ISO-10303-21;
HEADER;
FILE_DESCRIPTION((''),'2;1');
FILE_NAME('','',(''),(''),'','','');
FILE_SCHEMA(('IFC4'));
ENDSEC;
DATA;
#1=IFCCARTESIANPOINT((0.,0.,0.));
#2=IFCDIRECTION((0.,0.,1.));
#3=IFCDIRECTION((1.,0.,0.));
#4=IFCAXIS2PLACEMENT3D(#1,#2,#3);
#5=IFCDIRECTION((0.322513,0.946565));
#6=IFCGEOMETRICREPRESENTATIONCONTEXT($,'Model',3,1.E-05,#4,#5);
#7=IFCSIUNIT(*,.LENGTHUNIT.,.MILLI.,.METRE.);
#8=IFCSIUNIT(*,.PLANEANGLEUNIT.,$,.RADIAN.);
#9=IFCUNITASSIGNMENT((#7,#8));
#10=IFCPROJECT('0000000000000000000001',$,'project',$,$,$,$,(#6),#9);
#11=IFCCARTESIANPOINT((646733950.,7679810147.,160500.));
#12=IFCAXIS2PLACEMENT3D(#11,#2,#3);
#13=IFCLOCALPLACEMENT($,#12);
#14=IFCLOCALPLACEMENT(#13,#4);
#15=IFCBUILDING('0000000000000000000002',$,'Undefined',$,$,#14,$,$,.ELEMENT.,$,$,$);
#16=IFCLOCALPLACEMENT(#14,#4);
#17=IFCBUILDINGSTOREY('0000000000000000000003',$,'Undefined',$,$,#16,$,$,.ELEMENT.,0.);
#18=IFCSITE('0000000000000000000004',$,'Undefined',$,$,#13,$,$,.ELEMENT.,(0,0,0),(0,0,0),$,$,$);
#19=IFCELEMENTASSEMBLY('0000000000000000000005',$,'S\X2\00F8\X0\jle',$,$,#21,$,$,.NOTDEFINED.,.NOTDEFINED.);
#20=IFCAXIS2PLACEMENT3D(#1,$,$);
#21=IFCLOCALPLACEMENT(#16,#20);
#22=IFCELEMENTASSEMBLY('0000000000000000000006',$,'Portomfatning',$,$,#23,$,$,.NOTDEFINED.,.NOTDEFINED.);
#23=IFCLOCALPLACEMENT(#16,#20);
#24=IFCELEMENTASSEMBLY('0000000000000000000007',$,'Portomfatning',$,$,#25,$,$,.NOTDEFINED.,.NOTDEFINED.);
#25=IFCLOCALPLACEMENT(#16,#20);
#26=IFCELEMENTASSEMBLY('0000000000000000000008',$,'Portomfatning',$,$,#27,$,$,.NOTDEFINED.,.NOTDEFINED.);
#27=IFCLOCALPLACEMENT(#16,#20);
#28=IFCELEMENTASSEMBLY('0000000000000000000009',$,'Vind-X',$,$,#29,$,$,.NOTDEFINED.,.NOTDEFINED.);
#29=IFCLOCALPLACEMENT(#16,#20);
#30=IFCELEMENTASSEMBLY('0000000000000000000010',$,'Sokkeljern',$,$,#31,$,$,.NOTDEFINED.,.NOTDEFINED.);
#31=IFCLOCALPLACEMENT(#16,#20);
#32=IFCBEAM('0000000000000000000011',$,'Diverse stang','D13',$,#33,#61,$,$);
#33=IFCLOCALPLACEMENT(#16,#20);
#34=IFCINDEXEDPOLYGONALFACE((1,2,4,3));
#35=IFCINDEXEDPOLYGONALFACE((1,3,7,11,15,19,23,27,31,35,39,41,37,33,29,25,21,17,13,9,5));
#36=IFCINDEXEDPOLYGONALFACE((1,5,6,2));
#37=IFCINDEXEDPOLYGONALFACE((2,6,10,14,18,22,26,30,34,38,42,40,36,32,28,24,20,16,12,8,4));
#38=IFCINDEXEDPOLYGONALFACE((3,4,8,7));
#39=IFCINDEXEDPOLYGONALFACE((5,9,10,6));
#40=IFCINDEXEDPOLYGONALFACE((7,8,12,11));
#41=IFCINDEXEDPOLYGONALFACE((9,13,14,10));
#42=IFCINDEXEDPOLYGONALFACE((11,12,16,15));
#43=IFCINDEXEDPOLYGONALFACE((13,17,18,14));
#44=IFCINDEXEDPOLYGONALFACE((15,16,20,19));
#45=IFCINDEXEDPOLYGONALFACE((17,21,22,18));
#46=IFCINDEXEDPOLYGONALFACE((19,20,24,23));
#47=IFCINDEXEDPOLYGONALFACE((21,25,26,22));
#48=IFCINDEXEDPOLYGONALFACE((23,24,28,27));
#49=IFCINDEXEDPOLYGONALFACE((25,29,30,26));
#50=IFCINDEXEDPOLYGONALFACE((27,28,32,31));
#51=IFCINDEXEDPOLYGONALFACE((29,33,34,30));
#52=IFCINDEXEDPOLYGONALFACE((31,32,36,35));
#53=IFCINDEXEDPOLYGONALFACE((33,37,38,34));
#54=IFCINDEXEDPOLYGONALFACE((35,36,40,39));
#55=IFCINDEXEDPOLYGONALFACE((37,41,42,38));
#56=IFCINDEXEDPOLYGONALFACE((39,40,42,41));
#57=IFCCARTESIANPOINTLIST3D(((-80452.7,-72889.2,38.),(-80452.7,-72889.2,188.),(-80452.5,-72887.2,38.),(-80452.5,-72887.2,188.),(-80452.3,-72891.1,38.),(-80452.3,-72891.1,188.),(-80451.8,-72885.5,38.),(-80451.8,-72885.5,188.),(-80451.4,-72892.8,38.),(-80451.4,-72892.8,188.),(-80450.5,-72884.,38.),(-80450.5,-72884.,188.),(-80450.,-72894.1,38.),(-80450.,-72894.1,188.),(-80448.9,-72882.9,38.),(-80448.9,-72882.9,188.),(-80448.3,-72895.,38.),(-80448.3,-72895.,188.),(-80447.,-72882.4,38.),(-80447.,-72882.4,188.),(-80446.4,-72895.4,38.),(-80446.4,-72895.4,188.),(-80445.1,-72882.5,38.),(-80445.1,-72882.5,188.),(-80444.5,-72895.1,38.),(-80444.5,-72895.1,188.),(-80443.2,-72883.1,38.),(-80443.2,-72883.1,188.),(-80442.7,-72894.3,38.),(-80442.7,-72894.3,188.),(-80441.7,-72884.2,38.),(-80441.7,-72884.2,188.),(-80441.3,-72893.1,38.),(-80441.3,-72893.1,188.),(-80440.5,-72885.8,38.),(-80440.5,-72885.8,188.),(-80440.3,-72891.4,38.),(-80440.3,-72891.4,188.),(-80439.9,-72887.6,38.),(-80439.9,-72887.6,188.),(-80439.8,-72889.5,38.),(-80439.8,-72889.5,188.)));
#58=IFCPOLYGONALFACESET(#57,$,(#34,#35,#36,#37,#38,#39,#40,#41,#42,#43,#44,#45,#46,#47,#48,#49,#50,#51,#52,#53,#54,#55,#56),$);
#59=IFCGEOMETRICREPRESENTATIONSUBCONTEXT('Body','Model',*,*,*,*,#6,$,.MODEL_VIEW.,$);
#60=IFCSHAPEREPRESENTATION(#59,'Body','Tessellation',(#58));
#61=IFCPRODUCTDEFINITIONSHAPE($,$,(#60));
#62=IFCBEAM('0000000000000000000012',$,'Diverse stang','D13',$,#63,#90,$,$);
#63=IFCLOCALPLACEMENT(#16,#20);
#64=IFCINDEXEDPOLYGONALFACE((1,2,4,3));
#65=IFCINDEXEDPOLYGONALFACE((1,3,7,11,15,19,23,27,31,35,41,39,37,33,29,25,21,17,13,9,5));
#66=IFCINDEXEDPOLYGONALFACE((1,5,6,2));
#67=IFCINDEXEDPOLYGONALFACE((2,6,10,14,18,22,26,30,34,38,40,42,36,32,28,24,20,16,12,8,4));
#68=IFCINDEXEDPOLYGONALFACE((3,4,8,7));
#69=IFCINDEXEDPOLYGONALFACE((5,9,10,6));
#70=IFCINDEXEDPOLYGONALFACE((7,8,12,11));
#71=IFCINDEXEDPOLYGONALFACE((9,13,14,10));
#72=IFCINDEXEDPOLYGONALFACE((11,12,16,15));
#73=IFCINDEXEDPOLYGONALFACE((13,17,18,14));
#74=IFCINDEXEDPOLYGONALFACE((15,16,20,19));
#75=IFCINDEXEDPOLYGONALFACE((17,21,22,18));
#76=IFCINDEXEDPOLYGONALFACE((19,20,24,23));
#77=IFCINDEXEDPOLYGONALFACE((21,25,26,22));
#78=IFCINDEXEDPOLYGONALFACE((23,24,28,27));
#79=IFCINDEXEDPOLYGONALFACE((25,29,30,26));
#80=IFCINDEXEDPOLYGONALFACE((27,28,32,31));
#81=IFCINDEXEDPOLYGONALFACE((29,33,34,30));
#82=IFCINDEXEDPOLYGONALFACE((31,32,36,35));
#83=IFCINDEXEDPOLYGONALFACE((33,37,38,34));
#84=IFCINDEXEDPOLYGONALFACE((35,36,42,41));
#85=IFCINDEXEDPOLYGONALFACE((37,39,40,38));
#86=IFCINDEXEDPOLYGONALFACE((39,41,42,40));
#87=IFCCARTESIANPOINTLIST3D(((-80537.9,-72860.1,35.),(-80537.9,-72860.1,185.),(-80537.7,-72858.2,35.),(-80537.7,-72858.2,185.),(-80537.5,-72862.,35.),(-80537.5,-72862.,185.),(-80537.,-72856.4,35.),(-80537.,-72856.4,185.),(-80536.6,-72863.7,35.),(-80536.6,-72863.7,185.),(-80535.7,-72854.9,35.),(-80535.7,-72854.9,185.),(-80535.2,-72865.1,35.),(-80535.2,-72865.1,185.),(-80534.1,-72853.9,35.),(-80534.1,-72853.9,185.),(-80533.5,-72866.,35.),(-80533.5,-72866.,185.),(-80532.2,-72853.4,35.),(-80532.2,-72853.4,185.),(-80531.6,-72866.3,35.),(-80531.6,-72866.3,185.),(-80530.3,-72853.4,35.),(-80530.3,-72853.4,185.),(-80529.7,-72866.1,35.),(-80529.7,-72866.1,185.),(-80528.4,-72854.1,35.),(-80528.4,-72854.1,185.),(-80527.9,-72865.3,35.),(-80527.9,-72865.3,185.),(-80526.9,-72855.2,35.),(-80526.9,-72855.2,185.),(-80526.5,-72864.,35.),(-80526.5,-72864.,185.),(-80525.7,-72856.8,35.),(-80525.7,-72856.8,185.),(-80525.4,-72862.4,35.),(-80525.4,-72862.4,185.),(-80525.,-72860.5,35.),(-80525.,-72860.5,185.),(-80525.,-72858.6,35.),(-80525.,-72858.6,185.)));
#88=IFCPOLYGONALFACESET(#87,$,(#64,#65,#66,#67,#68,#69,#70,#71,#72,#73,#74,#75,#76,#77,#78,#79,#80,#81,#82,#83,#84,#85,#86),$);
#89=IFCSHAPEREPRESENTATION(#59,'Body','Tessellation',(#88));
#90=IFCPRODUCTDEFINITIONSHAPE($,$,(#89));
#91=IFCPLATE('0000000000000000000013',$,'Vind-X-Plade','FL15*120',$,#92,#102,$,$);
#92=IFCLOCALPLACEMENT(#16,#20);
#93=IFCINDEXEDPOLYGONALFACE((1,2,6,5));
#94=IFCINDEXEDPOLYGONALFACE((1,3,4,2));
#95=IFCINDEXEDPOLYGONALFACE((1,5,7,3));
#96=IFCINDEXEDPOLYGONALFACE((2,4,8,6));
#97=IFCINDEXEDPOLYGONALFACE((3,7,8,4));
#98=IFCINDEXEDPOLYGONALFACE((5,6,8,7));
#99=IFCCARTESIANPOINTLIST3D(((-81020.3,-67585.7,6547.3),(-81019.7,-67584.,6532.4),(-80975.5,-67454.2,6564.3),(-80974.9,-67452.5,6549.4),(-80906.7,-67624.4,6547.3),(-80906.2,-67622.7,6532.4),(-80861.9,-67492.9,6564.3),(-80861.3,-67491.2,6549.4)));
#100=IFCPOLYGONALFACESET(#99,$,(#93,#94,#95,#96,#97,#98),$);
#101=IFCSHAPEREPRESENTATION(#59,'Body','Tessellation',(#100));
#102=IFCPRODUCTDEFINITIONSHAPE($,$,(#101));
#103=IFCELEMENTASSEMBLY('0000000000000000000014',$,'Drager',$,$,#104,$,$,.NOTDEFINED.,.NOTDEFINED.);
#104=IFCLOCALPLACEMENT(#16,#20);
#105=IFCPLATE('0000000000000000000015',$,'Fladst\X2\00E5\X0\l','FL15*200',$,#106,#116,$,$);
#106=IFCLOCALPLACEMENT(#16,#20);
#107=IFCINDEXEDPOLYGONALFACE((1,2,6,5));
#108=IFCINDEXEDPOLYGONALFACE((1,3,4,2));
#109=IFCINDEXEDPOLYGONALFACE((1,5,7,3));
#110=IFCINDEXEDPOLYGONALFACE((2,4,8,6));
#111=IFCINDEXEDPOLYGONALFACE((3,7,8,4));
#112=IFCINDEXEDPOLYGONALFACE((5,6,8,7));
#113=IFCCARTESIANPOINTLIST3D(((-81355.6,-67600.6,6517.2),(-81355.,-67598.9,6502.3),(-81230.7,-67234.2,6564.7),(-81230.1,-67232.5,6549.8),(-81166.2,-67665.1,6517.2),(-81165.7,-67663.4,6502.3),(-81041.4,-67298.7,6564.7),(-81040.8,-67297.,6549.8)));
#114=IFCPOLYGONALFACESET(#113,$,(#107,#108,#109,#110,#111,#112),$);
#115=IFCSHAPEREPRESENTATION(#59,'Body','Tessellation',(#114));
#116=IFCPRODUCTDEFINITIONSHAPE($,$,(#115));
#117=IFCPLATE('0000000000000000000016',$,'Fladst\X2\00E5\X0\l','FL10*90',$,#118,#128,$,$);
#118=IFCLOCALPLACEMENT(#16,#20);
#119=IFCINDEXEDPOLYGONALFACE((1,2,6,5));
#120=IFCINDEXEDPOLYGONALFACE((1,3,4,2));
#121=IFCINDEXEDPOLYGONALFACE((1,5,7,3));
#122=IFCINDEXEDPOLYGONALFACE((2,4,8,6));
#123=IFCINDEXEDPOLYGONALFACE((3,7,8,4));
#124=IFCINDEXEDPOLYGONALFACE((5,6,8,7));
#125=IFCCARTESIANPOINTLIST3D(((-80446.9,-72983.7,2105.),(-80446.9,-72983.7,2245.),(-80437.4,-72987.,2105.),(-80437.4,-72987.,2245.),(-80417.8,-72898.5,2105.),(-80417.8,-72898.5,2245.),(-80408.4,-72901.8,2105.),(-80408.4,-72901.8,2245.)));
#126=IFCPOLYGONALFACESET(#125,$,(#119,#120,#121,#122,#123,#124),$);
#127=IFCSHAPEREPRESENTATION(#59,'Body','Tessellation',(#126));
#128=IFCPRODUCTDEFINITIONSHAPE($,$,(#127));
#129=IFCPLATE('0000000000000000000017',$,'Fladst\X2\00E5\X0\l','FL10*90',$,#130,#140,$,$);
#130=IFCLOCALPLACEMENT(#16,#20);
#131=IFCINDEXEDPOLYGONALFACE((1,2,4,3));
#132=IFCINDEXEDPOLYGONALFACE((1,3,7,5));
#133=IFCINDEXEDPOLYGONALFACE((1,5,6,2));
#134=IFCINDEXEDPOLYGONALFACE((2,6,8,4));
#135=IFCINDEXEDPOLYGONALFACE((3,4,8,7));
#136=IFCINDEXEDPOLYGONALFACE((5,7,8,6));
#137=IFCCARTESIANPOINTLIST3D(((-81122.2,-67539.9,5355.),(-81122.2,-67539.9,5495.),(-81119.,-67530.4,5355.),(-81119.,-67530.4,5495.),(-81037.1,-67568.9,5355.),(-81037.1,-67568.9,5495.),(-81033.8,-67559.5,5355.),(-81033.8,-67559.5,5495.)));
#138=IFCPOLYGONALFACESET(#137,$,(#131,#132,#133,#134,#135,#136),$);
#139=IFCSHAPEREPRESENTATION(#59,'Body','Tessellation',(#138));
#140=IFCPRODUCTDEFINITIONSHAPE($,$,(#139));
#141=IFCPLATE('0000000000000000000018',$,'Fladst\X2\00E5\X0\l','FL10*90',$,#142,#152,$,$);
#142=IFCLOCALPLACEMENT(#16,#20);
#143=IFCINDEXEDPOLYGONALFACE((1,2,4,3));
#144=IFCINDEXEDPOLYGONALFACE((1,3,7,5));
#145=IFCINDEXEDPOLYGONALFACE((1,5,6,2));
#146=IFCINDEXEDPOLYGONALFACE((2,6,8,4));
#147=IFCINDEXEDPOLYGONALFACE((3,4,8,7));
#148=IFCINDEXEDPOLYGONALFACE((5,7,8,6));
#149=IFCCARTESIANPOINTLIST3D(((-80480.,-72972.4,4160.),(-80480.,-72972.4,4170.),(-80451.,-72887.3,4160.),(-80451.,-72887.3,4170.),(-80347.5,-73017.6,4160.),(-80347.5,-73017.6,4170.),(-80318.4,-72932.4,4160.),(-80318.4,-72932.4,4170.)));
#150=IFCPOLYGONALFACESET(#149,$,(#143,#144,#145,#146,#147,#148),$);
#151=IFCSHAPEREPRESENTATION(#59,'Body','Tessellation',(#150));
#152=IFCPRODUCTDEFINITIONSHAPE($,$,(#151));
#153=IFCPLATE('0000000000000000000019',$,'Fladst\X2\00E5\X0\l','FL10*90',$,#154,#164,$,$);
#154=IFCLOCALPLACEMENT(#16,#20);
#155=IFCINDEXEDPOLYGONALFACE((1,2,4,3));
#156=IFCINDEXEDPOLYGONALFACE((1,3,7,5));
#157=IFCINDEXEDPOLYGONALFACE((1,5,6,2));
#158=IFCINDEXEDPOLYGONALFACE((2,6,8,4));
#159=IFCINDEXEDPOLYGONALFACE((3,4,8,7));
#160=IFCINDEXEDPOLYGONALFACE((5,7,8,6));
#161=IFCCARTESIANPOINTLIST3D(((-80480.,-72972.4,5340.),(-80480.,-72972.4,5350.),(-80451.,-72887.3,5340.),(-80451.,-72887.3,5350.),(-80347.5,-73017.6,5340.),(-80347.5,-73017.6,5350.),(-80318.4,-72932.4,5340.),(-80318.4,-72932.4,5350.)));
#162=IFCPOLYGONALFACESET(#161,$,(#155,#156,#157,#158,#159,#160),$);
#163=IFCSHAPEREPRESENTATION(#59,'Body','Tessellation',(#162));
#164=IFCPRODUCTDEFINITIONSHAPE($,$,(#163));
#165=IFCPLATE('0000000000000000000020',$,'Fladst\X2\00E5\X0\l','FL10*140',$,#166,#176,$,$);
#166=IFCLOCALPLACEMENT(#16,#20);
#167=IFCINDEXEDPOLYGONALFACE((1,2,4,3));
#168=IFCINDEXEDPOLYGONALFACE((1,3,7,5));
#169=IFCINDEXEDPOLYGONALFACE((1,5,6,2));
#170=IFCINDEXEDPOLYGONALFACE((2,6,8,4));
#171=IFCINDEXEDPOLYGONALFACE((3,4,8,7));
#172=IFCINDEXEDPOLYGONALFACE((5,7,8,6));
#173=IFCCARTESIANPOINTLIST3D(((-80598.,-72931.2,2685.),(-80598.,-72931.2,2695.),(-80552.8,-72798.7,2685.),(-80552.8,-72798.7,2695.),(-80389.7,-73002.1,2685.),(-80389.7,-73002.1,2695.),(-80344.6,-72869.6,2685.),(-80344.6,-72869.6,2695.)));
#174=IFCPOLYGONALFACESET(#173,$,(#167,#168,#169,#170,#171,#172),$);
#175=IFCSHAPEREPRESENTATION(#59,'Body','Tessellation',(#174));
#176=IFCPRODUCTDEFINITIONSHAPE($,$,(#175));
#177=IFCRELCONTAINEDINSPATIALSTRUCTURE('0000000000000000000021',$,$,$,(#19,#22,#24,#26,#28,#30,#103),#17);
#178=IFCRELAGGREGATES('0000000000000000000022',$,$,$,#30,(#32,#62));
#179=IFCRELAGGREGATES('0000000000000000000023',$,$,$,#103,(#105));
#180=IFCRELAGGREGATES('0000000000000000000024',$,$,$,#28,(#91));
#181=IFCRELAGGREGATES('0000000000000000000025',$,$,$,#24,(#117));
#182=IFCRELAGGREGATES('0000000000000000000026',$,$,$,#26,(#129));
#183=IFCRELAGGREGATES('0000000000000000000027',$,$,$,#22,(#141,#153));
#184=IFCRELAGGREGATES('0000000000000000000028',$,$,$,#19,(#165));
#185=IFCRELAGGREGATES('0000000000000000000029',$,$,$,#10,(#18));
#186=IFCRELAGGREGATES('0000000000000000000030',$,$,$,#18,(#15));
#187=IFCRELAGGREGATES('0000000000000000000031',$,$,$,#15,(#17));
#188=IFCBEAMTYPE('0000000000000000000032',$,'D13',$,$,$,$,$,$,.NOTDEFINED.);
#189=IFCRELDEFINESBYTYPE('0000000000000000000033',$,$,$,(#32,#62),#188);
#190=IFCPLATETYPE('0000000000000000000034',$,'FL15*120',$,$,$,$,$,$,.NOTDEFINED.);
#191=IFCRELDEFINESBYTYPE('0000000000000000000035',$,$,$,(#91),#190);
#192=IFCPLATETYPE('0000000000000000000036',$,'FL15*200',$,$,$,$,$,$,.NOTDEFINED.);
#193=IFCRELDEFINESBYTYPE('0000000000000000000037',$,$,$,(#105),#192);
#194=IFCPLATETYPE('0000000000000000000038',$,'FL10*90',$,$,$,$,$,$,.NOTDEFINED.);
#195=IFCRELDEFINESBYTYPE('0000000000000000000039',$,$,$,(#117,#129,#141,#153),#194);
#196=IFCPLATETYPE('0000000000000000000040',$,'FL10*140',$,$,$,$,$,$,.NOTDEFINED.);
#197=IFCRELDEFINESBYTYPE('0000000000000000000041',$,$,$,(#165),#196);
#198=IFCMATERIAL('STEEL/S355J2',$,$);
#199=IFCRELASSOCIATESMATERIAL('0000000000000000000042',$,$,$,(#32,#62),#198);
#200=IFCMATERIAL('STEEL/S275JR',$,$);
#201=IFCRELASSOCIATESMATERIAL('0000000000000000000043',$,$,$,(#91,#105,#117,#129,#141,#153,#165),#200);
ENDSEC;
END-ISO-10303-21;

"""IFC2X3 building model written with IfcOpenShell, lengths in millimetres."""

from ifc_helpers import new_model, si_unit, direction, frame, origin_with_axes, origin_2d_with_axis, place, context, subcontext, project, spatial, polyline, circle, outline, extrude, material, type_object, element, aggregate, save


model = new_model("IFC2X3")

# Units and contexts
model_context = context("Model", 3, precision=1e-05, world=origin_with_axes(), true_north=direction((0.322513, 0.946565)))
body_context = subcontext(model_context, "Body", "Model", "MODEL_VIEW")
ifc_project = project(units=[si_unit("LENGTHUNIT", "METRE", prefix="MILLI"), si_unit("PLANEANGLEUNIT", "RADIAN")], contexts=[model_context])

# Site, building, storey
site_placement = place(None, frame((646733950.0, 7679810147.0, 160500.0), z_axis=(0.0, 0.0, 1.0), x_axis=(1.0, 0.0, 0.0)))
site = spatial("IfcSite", under=ifc_project, at=site_placement, Name="Undefined", CompositionType="ELEMENT", RefLatitude=(0, 0, 0), RefLongitude=(0, 0, 0))
building_placement = place(site_placement, origin_with_axes())
building = spatial("IfcBuilding", under=site, at=building_placement, Name="Undefined", CompositionType="ELEMENT")
storey_placement = place(building_placement, origin_with_axes())
storey = spatial("IfcBuildingStorey", under=building, at=storey_placement, Name="Undefined", CompositionType="ELEMENT", Elevation=0.0)

# Element assemblies
assembly_1_placement = place(storey_placement, origin_with_axes())
assembly_1 = element("IfcElementAssembly", 1, at=assembly_1_placement, inside=storey, Name="Søjle", AssemblyPlace="NOTDEFINED", PredefinedType="NOTDEFINED")
assembly_2_placement = place(storey_placement, origin_with_axes())
assembly_2 = element("IfcElementAssembly", 2, at=assembly_2_placement, inside=storey, Name="Portomfatning", AssemblyPlace="NOTDEFINED", PredefinedType="NOTDEFINED")

# Shared definitions
ifc_material_1 = material(Name="STEEL/S355J2")

# Element assemblies
assembly_3_placement = place(storey_placement, origin_with_axes())
assembly_3 = element("IfcElementAssembly", 3, at=assembly_3_placement, inside=storey, Name="Portomfatning", AssemblyPlace="NOTDEFINED", PredefinedType="NOTDEFINED")
assembly_4_placement = place(storey_placement, origin_with_axes())
assembly_4 = element("IfcElementAssembly", 4, at=assembly_4_placement, inside=storey, Name="Portomfatning", AssemblyPlace="NOTDEFINED", PredefinedType="NOTDEFINED")
assembly_5_placement = place(storey_placement, origin_with_axes())
assembly_5 = element("IfcElementAssembly", 5, at=assembly_5_placement, inside=storey, Name="Vind-X", AssemblyPlace="NOTDEFINED", PredefinedType="NOTDEFINED")

# Element assembly, beams
assembly_6_placement = place(storey_placement, origin_with_axes())
assembly_6 = element("IfcElementAssembly", 6, at=assembly_6_placement, inside=storey, Name="Sokkeljern", AssemblyPlace="NOTDEFINED", PredefinedType="NOTDEFINED")
beam_type_1 = type_object("IfcBeamType", Name="D13", PredefinedType="NOTDEFINED")
beam_1_placement = place(assembly_6_placement, frame((-80446.2, -72888.9, 188.0), z_axis=(0.946565, -0.322513, 0.0), x_axis=(0.0, 0.0, -1.0)))
beam_1 = element("IfcBeam", 7, at=beam_1_placement, type_object=beam_type_1, material=ifc_material_1, Name="Diverse stang", Description="D13", context=body_context, shape_type="SweptSolid", body=[
    extrude(circle(Radius=6.5, at=origin_2d_with_axis()), frame((150.0, 0.0, 0.0), z_axis=(-1.0, 0.0, 0.0), x_axis=(0.0, -1.0, 0.0)), (0.0, 0.0, 1.0), 150.0),
])
beam_2_placement = place(assembly_6_placement, frame((-80531.4, -72859.8, 185.0), z_axis=(0.946565, -0.322513, 0.0), x_axis=(0.0, 0.0, -1.0)))
beam_2 = element("IfcBeam", 8, at=beam_2_placement, type_object=beam_type_1, material=ifc_material_1, Name="Diverse stang", Description="D13", context=body_context, shape_type="SweptSolid", body=[
    extrude(circle(Radius=6.5, at=origin_2d_with_axis()), frame((150.0, 0.0, 0.0), z_axis=(-1.0, 0.0, 0.0), x_axis=(0.0, -1.0, 0.0)), (0.0, 0.0, 1.0), 150.0),
])

# Plate
ifc_material_2 = material(Name="STEEL/S275JR")
plate_type_1 = type_object("IfcPlateType", Name="FL15*120", PredefinedType="NOTDEFINED")
plate_1_placement = place(assembly_5_placement, frame((-80997.6, -67519.1, 6548.4), z_axis=(0.039304, 0.115357, -0.992546), x_axis=(0.946565, -0.322513, 0.0)))
plate_1 = element("IfcPlate", 9, at=plate_1_placement, type_object=plate_type_1, material=ifc_material_2, Name="Vind-X-Plade", Description="FL15*120", context=body_context, shape_type="SweptSolid", body=[
    extrude(outline(polyline([(0.0, -70.0), (0.0, 70.0), (120.0, 70.0), (120.0, -70.0), (0.0, -70.0)])), frame((0.0, 0.0, -7.5), z_axis=(0.0, 0.0, 1.0), x_axis=(1.0, 0.0, 0.0)), (0.0, 0.0, 1.0), 15.0),
])

# Element assembly, plate
assembly_7_placement = place(storey_placement, origin_with_axes())
assembly_7 = element("IfcElementAssembly", 10, at=assembly_7_placement, inside=storey, Name="Drager", AssemblyPlace="NOTDEFINED", PredefinedType="NOTDEFINED")
plate_type_2 = type_object("IfcPlateType", Name="FL15*200", PredefinedType="NOTDEFINED")
plate_2_placement = place(assembly_7_placement, frame((-81165.9, -67664.3, 6509.7), z_axis=(-0.039304, -0.115357, 0.992546), x_axis=(0.320109, 0.93951, 0.121869)))
plate_2 = element("IfcPlate", 11, at=plate_2_placement, type_object=plate_type_2, material=ifc_material_2, Name="Fladstål", Description="FL15*200", context=body_context, shape_type="SweptSolid", body=[
    extrude(outline(polyline([(0.0, 0.0), (390.0, 0.0), (390.0, 200.0), (0.0, 200.0), (0.0, 0.0)])), frame((0.0, 0.0, -7.5), z_axis=(0.0, 0.0, 1.0), x_axis=(1.0, 0.0, 0.0)), (0.0, 0.0, 1.0), 15.0),
])

# Plates
plate_type_3 = type_object("IfcPlateType", Name="FL10*90", PredefinedType="NOTDEFINED")
plate_3_placement = place(assembly_3_placement, frame((-80427.6, -72942.7, 2105.0), z_axis=(0.946565, -0.322513, 0.0), x_axis=(0.0, 0.0, 1.0)))
plate_3 = element("IfcPlate", 12, at=plate_3_placement, type_object=plate_type_3, material=ifc_material_2, Name="Fladstål", Description="FL10*90", context=body_context, shape_type="SweptSolid", body=[
    extrude(outline(polyline([(0.0, -45.0), (0.0, 45.0), (140.0, 45.0), (140.0, -45.0), (0.0, -45.0)])), frame((0.0, 0.0, -5.0), z_axis=(0.0, 0.0, 1.0), x_axis=(1.0, 0.0, 0.0)), (0.0, 0.0, 1.0), 10.0),
])
plate_4_placement = place(assembly_4_placement, frame((-81078.0, -67549.7, 5355.0), z_axis=(-0.322513, -0.946565, 0.0), x_axis=(0.0, 0.0, 1.0)))
plate_4 = element("IfcPlate", 13, at=plate_4_placement, type_object=plate_type_3, material=ifc_material_2, Name="Fladstål", Description="FL10*90", context=body_context, shape_type="SweptSolid", body=[
    extrude(outline(polyline([(0.0, -45.0), (0.0, 45.0), (140.0, 45.0), (140.0, -45.0), (0.0, -45.0)])), frame((0.0, 0.0, -5.0), z_axis=(0.0, 0.0, 1.0), x_axis=(1.0, 0.0, 0.0)), (0.0, 0.0, 1.0), 10.0),
])
plate_5_placement = place(assembly_2_placement, frame((-80465.5, -72929.8, 4165.0), z_axis=(0.0, 0.0, 1.0), x_axis=(0.946565, -0.322513, 0.0)))
plate_5 = element("IfcPlate", 14, at=plate_5_placement, type_object=plate_type_3, material=ifc_material_2, Name="Fladstål", Description="FL10*90", context=body_context, shape_type="SweptSolid", body=[
    extrude(outline(polyline([(0.0, -45.0), (0.0, 45.0), (140.0, 45.0), (140.0, -45.0), (0.0, -45.0)])), frame((0.0, 0.0, -5.0), z_axis=(0.0, 0.0, 1.0), x_axis=(1.0, 0.0, 0.0)), (0.0, 0.0, 1.0), 10.0),
])
plate_6_placement = place(assembly_2_placement, frame((-80465.5, -72929.8, 5345.0), z_axis=(0.0, 0.0, -1.0), x_axis=(0.946565, -0.322513, 0.0)))
plate_6 = element("IfcPlate", 15, at=plate_6_placement, type_object=plate_type_3, material=ifc_material_2, Name="Fladstål", Description="FL10*90", context=body_context, shape_type="SweptSolid", body=[
    extrude(outline(polyline([(0.0, -45.0), (0.0, 45.0), (140.0, 45.0), (140.0, -45.0), (0.0, -45.0)])), frame((0.0, 0.0, -5.0), z_axis=(0.0, 0.0, 1.0), x_axis=(1.0, 0.0, 0.0)), (0.0, 0.0, 1.0), 10.0),
])
plate_type_4 = type_object("IfcPlateType", Name="FL10*140", PredefinedType="NOTDEFINED")
plate_7_placement = place(assembly_1_placement, frame((-80448.7, -72834.1, 2690.0), z_axis=(0.0, 0.0, -1.0), x_axis=(-0.322513, -0.946565, 0.0)))
plate_7 = element("IfcPlate", 16, at=plate_7_placement, type_object=plate_type_4, material=ifc_material_2, Name="Fladstål", Description="FL10*140", context=body_context, shape_type="SweptSolid", body=[
    extrude(outline(polyline([(0.0, -110.0), (0.0, 110.0), (140.0, 110.0), (140.0, -110.0), (0.0, -110.0)])), frame((0.0, 0.0, -5.0), z_axis=(0.0, 0.0, 1.0), x_axis=(1.0, 0.0, 0.0)), (0.0, 0.0, 1.0), 10.0),
])

aggregate(assembly_6, [beam_1, beam_2])

aggregate(assembly_7, [plate_2])
aggregate(assembly_5, [plate_1])
aggregate(assembly_3, [plate_3])
aggregate(assembly_4, [plate_4])
aggregate(assembly_2, [plate_5, plate_6])
aggregate(assembly_1, [plate_7])

save(model, "model.ifc")
